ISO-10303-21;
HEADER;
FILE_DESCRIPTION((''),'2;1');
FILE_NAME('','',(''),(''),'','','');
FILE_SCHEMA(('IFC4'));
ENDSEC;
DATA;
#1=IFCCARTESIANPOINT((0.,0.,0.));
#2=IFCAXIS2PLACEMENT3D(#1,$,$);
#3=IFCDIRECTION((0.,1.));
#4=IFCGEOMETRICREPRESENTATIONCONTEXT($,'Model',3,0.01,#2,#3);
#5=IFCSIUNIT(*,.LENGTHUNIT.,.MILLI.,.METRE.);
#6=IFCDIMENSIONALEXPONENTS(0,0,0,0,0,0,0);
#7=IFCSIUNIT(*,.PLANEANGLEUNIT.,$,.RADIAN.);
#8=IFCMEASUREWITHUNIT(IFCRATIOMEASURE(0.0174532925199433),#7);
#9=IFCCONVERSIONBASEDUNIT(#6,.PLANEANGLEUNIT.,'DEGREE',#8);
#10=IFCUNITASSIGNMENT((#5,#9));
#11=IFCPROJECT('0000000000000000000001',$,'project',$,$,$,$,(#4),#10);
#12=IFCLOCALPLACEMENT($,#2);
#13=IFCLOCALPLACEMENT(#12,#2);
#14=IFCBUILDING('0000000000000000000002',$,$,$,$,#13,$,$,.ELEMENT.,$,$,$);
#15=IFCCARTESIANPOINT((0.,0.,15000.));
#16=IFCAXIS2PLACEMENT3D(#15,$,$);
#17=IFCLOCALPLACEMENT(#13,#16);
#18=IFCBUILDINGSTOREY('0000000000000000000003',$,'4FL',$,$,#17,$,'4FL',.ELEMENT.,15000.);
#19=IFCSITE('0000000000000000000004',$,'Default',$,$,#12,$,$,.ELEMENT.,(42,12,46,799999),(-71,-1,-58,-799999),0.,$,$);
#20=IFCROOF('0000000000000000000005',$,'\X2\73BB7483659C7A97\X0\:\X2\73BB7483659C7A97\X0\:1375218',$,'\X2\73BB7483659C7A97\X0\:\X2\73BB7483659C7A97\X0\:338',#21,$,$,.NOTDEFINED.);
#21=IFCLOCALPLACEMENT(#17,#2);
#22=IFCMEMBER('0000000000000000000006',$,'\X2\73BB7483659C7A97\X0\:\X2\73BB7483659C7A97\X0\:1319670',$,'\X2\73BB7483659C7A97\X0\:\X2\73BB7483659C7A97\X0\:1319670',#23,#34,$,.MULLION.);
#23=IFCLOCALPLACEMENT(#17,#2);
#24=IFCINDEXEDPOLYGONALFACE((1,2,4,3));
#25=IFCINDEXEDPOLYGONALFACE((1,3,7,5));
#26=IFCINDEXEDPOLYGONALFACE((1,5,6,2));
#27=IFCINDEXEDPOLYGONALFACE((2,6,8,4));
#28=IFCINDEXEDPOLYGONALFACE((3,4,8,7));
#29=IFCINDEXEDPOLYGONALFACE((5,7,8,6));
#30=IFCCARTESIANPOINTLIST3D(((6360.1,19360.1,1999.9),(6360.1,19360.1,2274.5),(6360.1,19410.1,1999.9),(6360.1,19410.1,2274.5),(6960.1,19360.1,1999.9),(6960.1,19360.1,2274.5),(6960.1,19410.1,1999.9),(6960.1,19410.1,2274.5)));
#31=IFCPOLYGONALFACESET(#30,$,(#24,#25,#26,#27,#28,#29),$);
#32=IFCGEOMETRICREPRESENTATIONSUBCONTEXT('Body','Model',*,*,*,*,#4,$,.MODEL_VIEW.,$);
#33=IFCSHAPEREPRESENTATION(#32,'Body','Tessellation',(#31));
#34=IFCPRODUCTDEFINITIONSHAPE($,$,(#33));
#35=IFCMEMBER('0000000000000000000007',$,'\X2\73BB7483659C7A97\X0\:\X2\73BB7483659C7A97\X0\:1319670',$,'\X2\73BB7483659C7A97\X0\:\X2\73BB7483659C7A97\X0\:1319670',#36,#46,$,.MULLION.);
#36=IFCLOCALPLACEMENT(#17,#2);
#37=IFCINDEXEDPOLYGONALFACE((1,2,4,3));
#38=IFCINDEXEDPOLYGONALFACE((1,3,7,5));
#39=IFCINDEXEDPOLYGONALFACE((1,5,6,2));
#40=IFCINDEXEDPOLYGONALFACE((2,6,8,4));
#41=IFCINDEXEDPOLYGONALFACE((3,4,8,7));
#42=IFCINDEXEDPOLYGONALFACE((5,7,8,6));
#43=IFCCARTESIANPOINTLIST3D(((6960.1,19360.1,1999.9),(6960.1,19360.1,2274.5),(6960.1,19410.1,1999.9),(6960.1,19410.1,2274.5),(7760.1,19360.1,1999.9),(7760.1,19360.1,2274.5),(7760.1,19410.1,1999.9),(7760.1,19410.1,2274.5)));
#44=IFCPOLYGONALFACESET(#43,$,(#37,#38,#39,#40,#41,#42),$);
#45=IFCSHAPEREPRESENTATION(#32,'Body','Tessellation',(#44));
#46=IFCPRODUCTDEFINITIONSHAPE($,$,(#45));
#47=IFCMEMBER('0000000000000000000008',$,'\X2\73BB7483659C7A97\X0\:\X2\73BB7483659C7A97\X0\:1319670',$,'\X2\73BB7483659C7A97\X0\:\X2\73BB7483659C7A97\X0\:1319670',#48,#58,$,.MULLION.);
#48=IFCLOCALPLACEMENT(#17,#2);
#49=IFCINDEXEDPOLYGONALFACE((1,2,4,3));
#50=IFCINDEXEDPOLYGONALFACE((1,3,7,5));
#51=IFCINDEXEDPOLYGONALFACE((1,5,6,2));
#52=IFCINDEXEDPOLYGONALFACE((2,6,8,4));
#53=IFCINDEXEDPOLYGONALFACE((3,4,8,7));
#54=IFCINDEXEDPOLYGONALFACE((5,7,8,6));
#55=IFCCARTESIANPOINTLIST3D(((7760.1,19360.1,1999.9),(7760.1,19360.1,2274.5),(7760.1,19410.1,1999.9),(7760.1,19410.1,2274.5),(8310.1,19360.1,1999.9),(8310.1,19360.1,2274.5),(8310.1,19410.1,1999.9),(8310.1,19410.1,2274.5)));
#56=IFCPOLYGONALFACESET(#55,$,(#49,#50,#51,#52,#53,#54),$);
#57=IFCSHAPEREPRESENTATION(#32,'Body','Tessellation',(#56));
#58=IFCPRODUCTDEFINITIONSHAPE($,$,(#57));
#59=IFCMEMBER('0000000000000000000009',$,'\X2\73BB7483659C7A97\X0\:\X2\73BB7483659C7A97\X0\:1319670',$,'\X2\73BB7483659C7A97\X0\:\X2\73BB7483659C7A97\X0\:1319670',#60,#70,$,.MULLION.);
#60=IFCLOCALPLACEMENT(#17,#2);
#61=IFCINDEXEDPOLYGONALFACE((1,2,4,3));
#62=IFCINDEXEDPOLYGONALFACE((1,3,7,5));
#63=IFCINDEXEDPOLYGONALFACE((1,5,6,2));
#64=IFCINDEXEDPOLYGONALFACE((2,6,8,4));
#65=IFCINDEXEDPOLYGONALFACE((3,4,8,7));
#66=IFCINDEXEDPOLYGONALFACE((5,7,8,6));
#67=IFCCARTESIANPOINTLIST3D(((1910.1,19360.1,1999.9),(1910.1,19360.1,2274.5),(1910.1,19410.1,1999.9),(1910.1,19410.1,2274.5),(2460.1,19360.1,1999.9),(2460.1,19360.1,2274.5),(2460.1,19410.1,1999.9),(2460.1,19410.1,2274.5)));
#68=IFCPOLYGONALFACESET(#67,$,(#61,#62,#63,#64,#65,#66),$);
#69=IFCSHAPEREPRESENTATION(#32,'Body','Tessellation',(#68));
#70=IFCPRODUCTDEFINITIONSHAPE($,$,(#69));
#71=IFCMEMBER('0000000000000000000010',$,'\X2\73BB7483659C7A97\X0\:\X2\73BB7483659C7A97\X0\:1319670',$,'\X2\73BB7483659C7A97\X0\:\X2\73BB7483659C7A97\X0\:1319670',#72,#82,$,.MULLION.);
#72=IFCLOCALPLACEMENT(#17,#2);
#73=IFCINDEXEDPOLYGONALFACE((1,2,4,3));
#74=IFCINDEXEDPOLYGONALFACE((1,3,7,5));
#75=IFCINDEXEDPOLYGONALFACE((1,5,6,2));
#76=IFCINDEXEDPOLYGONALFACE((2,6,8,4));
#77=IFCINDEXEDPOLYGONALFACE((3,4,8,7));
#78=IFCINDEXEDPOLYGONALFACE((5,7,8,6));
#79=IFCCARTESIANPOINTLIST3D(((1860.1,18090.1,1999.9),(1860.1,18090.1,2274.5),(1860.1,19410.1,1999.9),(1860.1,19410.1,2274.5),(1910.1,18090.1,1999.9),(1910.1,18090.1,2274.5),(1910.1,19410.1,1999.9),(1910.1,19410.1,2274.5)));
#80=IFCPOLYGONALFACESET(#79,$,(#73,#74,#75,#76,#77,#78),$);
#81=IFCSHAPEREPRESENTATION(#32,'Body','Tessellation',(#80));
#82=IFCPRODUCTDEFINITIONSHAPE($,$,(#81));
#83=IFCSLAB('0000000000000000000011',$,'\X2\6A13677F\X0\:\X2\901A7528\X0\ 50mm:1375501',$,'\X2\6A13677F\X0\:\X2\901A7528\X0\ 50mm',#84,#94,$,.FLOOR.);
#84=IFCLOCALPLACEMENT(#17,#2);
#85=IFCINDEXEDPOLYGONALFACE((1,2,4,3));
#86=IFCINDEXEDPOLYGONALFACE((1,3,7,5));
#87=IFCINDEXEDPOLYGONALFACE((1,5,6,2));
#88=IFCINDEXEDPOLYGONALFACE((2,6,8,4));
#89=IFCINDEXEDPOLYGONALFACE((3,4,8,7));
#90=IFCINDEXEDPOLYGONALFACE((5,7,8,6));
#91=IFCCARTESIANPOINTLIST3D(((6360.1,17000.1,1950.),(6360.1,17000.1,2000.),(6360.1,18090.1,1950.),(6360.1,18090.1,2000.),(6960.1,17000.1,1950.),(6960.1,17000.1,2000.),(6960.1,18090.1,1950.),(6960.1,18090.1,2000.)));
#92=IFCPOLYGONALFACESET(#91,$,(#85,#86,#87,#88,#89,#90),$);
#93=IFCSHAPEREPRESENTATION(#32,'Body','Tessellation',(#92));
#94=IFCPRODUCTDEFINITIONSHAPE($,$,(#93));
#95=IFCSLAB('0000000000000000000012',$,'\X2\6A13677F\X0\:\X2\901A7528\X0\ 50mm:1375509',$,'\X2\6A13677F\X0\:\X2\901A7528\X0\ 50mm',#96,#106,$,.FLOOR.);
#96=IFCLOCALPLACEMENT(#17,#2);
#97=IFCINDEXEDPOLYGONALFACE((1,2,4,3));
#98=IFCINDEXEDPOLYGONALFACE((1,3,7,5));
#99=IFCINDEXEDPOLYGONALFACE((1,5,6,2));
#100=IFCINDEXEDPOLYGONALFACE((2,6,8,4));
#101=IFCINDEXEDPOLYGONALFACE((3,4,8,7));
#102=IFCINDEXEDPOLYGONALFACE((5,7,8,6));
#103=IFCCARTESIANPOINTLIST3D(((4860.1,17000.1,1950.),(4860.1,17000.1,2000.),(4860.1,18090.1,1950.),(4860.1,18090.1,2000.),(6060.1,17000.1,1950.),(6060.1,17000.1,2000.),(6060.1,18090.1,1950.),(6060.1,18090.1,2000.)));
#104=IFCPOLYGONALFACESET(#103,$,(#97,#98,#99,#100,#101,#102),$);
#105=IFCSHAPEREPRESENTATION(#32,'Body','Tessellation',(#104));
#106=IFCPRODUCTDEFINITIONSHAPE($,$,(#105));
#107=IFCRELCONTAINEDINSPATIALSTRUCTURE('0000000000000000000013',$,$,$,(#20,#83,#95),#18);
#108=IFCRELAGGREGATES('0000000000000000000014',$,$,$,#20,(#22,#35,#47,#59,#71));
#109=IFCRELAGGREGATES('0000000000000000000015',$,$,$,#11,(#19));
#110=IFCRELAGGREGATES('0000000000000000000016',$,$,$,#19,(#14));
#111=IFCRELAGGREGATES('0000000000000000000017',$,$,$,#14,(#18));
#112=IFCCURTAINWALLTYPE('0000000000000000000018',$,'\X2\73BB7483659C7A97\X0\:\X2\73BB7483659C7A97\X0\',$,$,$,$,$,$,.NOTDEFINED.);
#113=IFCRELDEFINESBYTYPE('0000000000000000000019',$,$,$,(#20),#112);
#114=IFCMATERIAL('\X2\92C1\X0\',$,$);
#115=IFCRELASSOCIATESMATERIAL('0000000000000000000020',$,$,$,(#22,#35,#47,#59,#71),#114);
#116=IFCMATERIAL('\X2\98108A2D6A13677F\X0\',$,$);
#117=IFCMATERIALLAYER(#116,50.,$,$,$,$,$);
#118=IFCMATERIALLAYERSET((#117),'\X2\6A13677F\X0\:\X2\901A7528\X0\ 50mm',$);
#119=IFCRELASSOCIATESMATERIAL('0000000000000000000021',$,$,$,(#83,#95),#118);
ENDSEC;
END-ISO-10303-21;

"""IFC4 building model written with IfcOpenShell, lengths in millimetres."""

from ifc_helpers import new_model, entity, si_unit, converted_unit, direction, frame, frame_2d, origin, place, context, subcontext, project, spatial, rectangle, extrude, material, layer, layer_set, layer_usage, type_object, element, aggregate, save


model = new_model("IFC4")

# Units and contexts
model_context = context("Model", 3, precision=0.01, world=origin(), true_north=direction((0.0, 1.0)))
body_context = subcontext(model_context, "Body", "Model", "MODEL_VIEW")
ifc_project = project(units=[si_unit("LENGTHUNIT", "METRE", prefix="MILLI"), converted_unit("PLANEANGLEUNIT", "DEGREE", entity("IfcRatioMeasure", 0.0174532925199433), si_unit("PLANEANGLEUNIT", "RADIAN"), dimensions=[0, 0, 0, 0, 0, 0, 0])], contexts=[model_context])

# Site, building, storey
site_placement = place(None, origin())
site = spatial("IfcSite", under=ifc_project, at=site_placement, Name="Default", CompositionType="ELEMENT", RefLatitude=(42, 12, 46, 799999), RefLongitude=(-71, -1, -58, -799999), RefElevation=0.0)
building_placement = place(site_placement, origin())
building = spatial("IfcBuilding", under=site, at=building_placement, CompositionType="ELEMENT")
storey_placement = place(building_placement, frame((0.0, 0.0, 15000.0)))
storey = spatial("IfcBuildingStorey", under=building, at=storey_placement, Name="4FL", LongName="4FL", CompositionType="ELEMENT", Elevation=15000.0)

# Roof, members
curtain_wall_type = type_object("IfcCurtainWallType", Name="玻璃斜窗:玻璃斜窗", PredefinedType="NOTDEFINED")
roof_placement = place(storey_placement, frame((0.0, 0.0, -15000.0)))
roof = element("IfcRoof", 1, at=roof_placement, inside=storey, type_object=curtain_wall_type, Name="玻璃斜窗:玻璃斜窗:1375218", ObjectType="玻璃斜窗:玻璃斜窗:338", PredefinedType="NOTDEFINED")
ifc_material_1 = material(Name="鋁")
member_1_placement = place(roof_placement, frame((0.0, 0.0, 15000.0)))
member_1 = element("IfcMember", 2, at=member_1_placement, material=ifc_material_1, Name="玻璃斜窗:玻璃斜窗:1319670", ObjectType="玻璃斜窗:玻璃斜窗:1319670", PredefinedType="MULLION", context=body_context, shape_type="SweptSolid", body=[
    extrude(rectangle(XDim=274.5, YDim=50.0, at=frame_2d((0.0, 0.0), x_axis=(1.0, 0.0))), frame((6360.1, 19385.1, 2137.2), z_axis=(1.0, 0.0, 0.0), x_axis=(0.0, 0.0, -1.0)), (0.0, 0.0, 1.0), 600.0),
])
member_2_placement = place(roof_placement, frame((0.0, 0.0, 15000.0)))
member_2 = element("IfcMember", 3, at=member_2_placement, material=ifc_material_1, Name="玻璃斜窗:玻璃斜窗:1319670", ObjectType="玻璃斜窗:玻璃斜窗:1319670", PredefinedType="MULLION", context=body_context, shape_type="SweptSolid", body=[
    extrude(rectangle(XDim=274.5, YDim=50.0, at=frame_2d((0.0, 0.0), x_axis=(1.0, 0.0))), frame((6960.1, 19385.1, 2137.2), z_axis=(1.0, 0.0, 0.0), x_axis=(0.0, 0.0, -1.0)), (0.0, 0.0, 1.0), 800.0),
])
member_3_placement = place(roof_placement, frame((0.0, 0.0, 15000.0)))
member_3 = element("IfcMember", 4, at=member_3_placement, material=ifc_material_1, Name="玻璃斜窗:玻璃斜窗:1319670", ObjectType="玻璃斜窗:玻璃斜窗:1319670", PredefinedType="MULLION", context=body_context, shape_type="SweptSolid", body=[
    extrude(rectangle(XDim=274.5, YDim=50.0, at=frame_2d((0.0, 0.0), x_axis=(1.0, 0.0))), frame((7760.1, 19385.1, 2137.2), z_axis=(1.0, 0.0, 0.0), x_axis=(0.0, 0.0, -1.0)), (0.0, 0.0, 1.0), 550.0),
])
member_4_placement = place(roof_placement, frame((0.0, 0.0, 15000.0)))
member_4 = element("IfcMember", 5, at=member_4_placement, material=ifc_material_1, Name="玻璃斜窗:玻璃斜窗:1319670", ObjectType="玻璃斜窗:玻璃斜窗:1319670", PredefinedType="MULLION", context=body_context, shape_type="SweptSolid", body=[
    extrude(rectangle(XDim=274.5, YDim=50.0, at=frame_2d((0.0, 0.0), x_axis=(1.0, 0.0))), frame((1910.1, 19385.1, 2137.2), z_axis=(1.0, 0.0, 0.0), x_axis=(0.0, 0.0, -1.0)), (0.0, 0.0, 1.0), 550.0),
])
member_5_placement = place(roof_placement, frame((0.0, 0.0, 15000.0)))
member_5 = element("IfcMember", 6, at=member_5_placement, material=ifc_material_1, Name="玻璃斜窗:玻璃斜窗:1319670", ObjectType="玻璃斜窗:玻璃斜窗:1319670", PredefinedType="MULLION", context=body_context, shape_type="SweptSolid", body=[
    extrude(rectangle(XDim=274.5, YDim=50.0, at=frame_2d((0.0, 0.0), x_axis=(1.0, 0.0))), frame((1885.1, 18090.1, 2137.2), z_axis=(0.0, 1.0, 0.0), x_axis=(0.0, 0.0, -1.0)), (0.0, 0.0, 1.0), 1320.0),
])
aggregate(roof, [member_1, member_2, member_3, member_4, member_5])

# Slabs
ifc_material_2 = material(Name="預設樓板")
ifc_layer = layer(ifc_material_2, 50.0)
ifc_layer_set = layer_set([ifc_layer], Name="樓板:通用 50mm")
ifc_layer_usage_1 = layer_usage(ifc_layer_set, "AXIS3", "POSITIVE", 0.0)
slab_1_placement = place(storey_placement, origin())
element("IfcSlab", 7, at=slab_1_placement, inside=storey, material=ifc_layer_usage_1, Name="樓板:通用 50mm:1375501", ObjectType="樓板:通用 50mm", PredefinedType="FLOOR", context=body_context, shape_type="SweptSolid", body=[
    extrude(rectangle(XDim=1090.0, YDim=600.0, at=frame_2d((0.0, 0.0), x_axis=(1.0, 0.0))), frame((6660.1, 17545.1, 2000.0), z_axis=(0.0, 0.0, -1.0), x_axis=(0.0, 1.0, 0.0)), (0.0, 0.0, 1.0), 50.0),
])
ifc_layer_usage_2 = layer_usage(ifc_layer_set, "AXIS3", "POSITIVE", 0.0)
slab_2_placement = place(storey_placement, origin())
element("IfcSlab", 8, at=slab_2_placement, inside=storey, material=ifc_layer_usage_2, Name="樓板:通用 50mm:1375509", ObjectType="樓板:通用 50mm", PredefinedType="FLOOR", context=body_context, shape_type="SweptSolid", body=[
    extrude(rectangle(XDim=1090.0, YDim=1200.0, at=frame_2d((0.0, 0.0), x_axis=(1.0, 0.0))), frame((5460.1, 17545.1, 2000.0), z_axis=(0.0, 0.0, -1.0), x_axis=(0.0, 1.0, 0.0)), (0.0, 0.0, 1.0), 50.0),
])

save(model, "model.ifc")
